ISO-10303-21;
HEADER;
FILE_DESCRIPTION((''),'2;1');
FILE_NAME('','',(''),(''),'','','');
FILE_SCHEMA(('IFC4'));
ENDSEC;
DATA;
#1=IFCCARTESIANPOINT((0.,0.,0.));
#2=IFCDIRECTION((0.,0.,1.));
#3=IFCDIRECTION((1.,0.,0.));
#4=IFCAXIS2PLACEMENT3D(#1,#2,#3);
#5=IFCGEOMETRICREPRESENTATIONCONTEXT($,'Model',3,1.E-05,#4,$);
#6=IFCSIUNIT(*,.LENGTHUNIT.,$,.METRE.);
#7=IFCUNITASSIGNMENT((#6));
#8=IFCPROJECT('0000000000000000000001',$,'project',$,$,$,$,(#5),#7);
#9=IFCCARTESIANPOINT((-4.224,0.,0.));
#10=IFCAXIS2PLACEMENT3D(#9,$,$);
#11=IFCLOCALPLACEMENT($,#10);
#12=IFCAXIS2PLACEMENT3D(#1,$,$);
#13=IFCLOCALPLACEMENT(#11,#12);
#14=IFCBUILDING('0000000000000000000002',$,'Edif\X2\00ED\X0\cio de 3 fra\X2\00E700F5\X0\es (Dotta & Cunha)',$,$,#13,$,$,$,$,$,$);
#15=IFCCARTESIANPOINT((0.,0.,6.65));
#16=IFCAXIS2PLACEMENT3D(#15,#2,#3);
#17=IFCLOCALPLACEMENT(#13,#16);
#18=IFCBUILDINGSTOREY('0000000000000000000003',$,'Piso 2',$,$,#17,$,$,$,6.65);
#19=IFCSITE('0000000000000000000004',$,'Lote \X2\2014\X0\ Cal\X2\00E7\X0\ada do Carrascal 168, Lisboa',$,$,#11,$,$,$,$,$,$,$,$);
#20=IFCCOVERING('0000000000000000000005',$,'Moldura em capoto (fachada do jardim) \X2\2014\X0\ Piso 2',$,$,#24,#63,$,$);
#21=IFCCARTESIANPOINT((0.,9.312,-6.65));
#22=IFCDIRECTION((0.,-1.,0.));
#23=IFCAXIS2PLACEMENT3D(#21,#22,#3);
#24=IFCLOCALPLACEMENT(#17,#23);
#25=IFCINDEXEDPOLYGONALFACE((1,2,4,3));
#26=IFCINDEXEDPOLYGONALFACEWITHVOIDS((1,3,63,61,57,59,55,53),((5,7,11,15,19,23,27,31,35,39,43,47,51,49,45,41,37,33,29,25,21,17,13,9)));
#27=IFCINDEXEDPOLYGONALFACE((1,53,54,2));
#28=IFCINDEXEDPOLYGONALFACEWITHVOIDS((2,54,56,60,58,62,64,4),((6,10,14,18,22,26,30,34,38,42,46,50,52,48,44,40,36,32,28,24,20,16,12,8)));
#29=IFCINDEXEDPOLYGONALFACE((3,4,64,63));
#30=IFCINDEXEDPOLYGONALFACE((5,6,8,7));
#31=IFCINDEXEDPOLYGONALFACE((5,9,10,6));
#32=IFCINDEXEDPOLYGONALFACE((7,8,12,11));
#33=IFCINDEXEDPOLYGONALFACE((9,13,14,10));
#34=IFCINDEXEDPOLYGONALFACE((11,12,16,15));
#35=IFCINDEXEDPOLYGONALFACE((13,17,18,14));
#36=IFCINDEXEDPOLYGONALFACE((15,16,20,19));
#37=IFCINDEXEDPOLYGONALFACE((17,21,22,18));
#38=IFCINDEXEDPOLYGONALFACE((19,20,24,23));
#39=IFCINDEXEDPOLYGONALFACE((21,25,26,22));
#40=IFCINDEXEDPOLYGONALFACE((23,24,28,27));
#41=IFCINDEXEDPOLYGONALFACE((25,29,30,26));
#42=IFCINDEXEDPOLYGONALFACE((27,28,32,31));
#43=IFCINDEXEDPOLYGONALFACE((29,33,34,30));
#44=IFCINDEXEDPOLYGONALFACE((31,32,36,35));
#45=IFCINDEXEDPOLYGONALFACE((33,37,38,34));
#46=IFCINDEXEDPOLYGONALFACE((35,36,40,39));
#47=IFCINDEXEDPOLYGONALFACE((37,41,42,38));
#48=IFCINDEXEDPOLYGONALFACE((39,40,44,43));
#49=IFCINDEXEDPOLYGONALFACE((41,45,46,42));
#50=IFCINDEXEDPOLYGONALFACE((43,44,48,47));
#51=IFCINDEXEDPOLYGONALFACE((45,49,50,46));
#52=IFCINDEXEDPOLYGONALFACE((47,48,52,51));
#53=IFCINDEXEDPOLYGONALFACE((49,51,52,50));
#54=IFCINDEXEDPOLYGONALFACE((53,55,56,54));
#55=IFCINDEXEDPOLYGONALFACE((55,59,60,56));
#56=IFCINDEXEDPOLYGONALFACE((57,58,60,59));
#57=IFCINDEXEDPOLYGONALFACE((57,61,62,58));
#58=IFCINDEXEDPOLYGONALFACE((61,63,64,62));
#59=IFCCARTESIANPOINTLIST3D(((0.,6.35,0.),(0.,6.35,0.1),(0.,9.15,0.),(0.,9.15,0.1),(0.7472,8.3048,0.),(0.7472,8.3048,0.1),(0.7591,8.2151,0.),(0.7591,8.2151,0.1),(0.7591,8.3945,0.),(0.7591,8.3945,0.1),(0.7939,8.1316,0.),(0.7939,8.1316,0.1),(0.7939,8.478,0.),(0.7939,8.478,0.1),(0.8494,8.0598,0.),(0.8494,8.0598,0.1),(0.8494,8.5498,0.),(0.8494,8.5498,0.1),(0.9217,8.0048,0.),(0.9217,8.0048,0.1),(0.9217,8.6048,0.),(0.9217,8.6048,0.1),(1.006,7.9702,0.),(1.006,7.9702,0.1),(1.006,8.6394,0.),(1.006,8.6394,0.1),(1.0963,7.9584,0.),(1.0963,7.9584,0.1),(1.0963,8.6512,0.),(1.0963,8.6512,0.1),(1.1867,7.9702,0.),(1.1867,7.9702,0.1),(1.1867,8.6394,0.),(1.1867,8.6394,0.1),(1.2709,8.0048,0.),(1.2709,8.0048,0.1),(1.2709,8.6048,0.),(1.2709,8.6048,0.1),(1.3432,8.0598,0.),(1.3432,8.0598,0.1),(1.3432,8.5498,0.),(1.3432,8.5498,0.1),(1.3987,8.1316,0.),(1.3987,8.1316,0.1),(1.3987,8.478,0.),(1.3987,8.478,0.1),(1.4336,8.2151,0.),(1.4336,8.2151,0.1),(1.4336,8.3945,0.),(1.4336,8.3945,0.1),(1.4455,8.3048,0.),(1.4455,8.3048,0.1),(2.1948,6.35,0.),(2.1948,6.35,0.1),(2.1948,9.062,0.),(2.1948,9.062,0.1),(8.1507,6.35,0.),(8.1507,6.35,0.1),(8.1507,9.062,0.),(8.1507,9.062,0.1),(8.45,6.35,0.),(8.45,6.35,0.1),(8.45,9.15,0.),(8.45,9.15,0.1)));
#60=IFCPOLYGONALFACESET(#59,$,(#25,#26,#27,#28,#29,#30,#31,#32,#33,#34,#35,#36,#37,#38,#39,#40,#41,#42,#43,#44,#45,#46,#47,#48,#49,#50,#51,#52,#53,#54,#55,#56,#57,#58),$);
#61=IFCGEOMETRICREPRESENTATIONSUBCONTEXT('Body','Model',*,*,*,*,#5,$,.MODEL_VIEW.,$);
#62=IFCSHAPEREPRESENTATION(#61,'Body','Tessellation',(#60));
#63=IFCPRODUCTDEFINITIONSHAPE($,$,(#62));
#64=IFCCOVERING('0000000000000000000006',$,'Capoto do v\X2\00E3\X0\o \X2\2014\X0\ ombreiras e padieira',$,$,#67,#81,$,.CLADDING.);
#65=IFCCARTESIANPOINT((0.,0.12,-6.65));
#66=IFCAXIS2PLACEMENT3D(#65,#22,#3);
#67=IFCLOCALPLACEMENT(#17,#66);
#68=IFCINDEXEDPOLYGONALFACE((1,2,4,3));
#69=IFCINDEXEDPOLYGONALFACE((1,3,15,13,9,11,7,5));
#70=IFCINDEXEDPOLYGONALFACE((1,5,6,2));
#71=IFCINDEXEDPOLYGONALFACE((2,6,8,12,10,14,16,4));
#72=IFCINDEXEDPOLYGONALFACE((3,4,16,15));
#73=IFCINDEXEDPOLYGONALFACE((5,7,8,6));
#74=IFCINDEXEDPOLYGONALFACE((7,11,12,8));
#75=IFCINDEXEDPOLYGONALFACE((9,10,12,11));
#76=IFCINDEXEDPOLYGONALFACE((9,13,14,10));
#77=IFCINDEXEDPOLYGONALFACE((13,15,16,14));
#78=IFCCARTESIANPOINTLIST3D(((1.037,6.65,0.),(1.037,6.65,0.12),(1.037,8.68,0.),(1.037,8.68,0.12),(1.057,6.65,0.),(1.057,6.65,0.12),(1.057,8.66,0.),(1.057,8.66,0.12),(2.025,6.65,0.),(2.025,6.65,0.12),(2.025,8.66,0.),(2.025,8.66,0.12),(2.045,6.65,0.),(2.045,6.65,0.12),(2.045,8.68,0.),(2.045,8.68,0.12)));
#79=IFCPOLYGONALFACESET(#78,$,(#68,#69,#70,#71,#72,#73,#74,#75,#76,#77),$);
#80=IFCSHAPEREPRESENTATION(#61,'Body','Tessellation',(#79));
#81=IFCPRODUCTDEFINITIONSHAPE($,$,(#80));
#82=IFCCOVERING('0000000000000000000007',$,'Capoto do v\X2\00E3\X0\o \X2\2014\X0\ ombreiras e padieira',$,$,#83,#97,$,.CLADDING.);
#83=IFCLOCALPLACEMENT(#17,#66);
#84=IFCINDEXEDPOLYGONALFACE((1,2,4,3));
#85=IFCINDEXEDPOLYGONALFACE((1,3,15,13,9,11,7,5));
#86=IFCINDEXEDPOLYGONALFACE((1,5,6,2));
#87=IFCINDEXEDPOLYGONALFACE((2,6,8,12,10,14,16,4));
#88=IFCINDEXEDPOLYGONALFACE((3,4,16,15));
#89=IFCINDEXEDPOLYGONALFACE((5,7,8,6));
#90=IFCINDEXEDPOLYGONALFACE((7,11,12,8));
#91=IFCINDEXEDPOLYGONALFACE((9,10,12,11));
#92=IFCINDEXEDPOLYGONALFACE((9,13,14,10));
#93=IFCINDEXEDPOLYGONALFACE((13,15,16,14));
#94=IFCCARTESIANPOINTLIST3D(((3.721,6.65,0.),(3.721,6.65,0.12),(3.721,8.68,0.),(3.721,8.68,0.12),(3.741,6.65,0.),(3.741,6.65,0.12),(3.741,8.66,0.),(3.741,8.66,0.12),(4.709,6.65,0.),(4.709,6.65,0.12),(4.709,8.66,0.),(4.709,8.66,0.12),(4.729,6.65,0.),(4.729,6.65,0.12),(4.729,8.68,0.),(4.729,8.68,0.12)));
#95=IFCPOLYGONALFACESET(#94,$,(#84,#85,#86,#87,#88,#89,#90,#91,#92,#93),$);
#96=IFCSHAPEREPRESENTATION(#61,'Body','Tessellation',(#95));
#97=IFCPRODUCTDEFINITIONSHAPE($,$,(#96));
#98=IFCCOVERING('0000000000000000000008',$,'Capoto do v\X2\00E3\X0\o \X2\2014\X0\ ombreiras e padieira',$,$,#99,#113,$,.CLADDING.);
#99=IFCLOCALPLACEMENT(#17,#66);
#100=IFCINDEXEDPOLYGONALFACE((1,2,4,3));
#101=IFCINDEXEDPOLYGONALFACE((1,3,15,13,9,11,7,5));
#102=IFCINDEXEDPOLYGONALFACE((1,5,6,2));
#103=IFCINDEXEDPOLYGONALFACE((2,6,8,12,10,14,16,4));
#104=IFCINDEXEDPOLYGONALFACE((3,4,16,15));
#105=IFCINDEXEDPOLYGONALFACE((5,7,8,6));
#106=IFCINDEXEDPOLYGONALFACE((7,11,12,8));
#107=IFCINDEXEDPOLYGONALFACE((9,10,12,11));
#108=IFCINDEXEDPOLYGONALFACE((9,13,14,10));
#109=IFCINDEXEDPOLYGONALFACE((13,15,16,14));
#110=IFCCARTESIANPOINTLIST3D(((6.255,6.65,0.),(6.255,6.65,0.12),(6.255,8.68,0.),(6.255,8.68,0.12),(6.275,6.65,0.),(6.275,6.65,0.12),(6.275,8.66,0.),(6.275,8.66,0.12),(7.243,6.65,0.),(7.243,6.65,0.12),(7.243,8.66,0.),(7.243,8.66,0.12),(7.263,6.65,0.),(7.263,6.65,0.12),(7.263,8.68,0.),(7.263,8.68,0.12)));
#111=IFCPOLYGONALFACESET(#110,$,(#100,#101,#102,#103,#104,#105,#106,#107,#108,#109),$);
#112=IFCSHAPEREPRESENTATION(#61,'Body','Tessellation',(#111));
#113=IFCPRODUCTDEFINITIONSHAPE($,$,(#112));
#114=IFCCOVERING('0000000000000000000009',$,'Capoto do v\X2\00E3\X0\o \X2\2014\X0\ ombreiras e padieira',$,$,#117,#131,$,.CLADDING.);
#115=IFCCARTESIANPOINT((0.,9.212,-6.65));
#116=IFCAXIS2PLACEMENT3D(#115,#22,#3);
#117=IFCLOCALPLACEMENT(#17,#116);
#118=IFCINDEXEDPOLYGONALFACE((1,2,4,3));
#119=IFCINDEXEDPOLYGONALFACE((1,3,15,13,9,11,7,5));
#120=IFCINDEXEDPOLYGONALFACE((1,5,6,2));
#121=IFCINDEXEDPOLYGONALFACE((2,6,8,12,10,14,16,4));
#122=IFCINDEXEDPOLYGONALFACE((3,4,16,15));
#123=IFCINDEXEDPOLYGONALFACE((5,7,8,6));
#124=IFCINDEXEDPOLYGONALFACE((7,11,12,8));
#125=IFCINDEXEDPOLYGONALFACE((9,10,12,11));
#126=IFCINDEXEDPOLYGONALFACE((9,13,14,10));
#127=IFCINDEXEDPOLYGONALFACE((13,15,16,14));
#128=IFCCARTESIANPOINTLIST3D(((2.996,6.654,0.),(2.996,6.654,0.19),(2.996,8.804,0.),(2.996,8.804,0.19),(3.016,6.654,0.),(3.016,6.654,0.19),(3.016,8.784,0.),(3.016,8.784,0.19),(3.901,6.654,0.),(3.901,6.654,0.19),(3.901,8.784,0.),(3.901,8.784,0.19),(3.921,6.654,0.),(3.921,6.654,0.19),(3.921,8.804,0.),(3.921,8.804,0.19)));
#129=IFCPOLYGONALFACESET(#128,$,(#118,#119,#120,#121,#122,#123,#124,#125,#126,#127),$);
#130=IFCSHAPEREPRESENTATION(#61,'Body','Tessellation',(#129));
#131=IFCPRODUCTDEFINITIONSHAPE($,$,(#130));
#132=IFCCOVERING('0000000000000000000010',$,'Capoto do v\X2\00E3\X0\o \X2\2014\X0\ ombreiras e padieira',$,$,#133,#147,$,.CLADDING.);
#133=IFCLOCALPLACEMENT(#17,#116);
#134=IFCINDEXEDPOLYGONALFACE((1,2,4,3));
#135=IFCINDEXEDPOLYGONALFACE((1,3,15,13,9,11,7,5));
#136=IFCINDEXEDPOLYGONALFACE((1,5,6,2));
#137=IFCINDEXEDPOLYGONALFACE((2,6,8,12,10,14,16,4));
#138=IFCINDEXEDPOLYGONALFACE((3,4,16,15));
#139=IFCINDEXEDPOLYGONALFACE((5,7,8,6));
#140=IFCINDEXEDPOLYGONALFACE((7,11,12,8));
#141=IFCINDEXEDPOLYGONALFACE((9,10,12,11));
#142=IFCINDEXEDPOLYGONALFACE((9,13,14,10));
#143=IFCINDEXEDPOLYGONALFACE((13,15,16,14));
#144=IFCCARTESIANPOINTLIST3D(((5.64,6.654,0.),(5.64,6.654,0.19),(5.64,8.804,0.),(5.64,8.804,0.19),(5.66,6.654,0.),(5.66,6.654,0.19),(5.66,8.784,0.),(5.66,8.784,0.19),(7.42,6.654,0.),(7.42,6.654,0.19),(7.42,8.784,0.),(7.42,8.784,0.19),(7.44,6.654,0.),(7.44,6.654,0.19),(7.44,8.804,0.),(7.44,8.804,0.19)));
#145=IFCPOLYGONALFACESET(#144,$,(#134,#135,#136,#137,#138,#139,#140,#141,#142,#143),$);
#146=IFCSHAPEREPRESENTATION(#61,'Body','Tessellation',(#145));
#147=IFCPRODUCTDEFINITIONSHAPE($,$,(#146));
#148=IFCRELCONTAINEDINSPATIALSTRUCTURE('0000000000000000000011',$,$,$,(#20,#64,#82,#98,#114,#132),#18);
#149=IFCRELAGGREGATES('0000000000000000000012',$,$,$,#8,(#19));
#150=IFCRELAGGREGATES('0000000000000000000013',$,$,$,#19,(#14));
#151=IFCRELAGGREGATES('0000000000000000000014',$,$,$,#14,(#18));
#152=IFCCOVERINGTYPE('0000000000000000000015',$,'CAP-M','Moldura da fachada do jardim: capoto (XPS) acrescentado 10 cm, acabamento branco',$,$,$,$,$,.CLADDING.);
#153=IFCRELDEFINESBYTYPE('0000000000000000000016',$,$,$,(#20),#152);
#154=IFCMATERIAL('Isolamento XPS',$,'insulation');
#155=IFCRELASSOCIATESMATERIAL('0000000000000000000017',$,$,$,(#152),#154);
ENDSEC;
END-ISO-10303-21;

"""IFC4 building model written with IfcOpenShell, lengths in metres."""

from ifc_helpers import new_model, si_unit, frame, origin, origin_with_axes, place, context, subcontext, project, spatial, line, indexed_curve, outline, extrude, material, type_object, element, save


model = new_model("IFC4")

# Units and contexts
model_context = context("Model", 3, precision=1e-05, world=origin_with_axes())
body_context = subcontext(model_context, "Body", "Model", "MODEL_VIEW")
ifc_project = project(units=[si_unit("LENGTHUNIT", "METRE")], contexts=[model_context])

# Site, building, storey
site_placement = place(None, frame((-4.224, 0.0, 0.0)))
site = spatial("IfcSite", under=ifc_project, at=site_placement, Name="Lote — Calçada do Carrascal 168, Lisboa")
building_placement = place(site_placement, origin())
building = spatial("IfcBuilding", under=site, at=building_placement, Name="Edifício de 3 frações (Dotta & Cunha)")
storey_placement = place(building_placement, frame((0.0, 0.0, 6.65), z_axis=(0.0, 0.0, 1.0), x_axis=(1.0, 0.0, 0.0)))
storey = spatial("IfcBuildingStorey", under=building, at=storey_placement, Name="Piso 2", Elevation=6.65)

# Covering
ifc_material_1 = material(Name="Isolamento XPS", Category="insulation")
covering_type_1 = type_object("IfcCoveringType", Name="CAP-M", Description="Moldura da fachada do jardim: capoto (XPS) acrescentado 10 cm, acabamento branco", PredefinedType="CLADDING", material=ifc_material_1)
covering_1_placement = place(storey_placement, frame((0.0, 9.312, -6.65), z_axis=(0.0, -1.0, 0.0), x_axis=(1.0, 0.0, 0.0)))
element("IfcCovering", 1, at=covering_1_placement, inside=storey, type_object=covering_type_1, Name="Moldura em capoto (fachada do jardim) — Piso 2", context=body_context, shape_type="SweptSolid", body=[
    extrude(outline(indexed_curve([(8.45, 6.35), (8.1507, 6.35), (8.1507, 9.062), (2.1948, 9.062), (2.1948, 6.35), (0.0, 6.35), (0.0, 9.15), (8.45, 9.15)], segments=[line(1, 2, 3, 4, 5, 6, 7, 8, 1)]), holes=[indexed_curve([(0.9217, 8.6048), (0.8494, 8.5498), (0.7939, 8.478), (0.7591, 8.3945), (0.7472, 8.3048), (0.7591, 8.2151), (0.7939, 8.1316), (0.8494, 8.0598), (0.9217, 8.0048), (1.006, 7.9702), (1.0963, 7.9584), (1.1867, 7.9702), (1.2709, 8.0048), (1.3432, 8.0598), (1.3987, 8.1316), (1.4336, 8.2151), (1.4455, 8.3048), (1.4336, 8.3945), (1.3987, 8.478), (1.3432, 8.5498), (1.2709, 8.6048), (1.1867, 8.6394), (1.0963, 8.6512), (1.006, 8.6394)], segments=[line(1, 2, 3, 4, 5, 6, 7, 8, 9, 10, 11, 12, 13, 14, 15, 16, 17, 18, 19, 20, 21, 22, 23, 24, 1)])]), origin_with_axes(), (0.0, 0.0, 1.0), 0.1),
])

# Coverings
covering_2_placement = place(storey_placement, frame((0.0, 0.12, -6.65), z_axis=(0.0, -1.0, 0.0), x_axis=(1.0, 0.0, 0.0)))
element("IfcCovering", 2, at=covering_2_placement, inside=storey, Name="Capoto do vão — ombreiras e padieira", PredefinedType="CLADDING", context=body_context, shape_type="SweptSolid", body=[
    extrude(outline(indexed_curve([(1.037, 6.65), (1.037, 8.68), (2.045, 8.68), (2.045, 6.65), (2.025, 6.65), (2.025, 8.66), (1.057, 8.66), (1.057, 6.65)], segments=[line(1, 2, 3, 4, 5, 6, 7, 8, 1)])), origin_with_axes(), (0.0, 0.0, 1.0), 0.12),
])
covering_3_placement = place(storey_placement, frame((0.0, 0.12, -6.65), z_axis=(0.0, -1.0, 0.0), x_axis=(1.0, 0.0, 0.0)))
element("IfcCovering", 3, at=covering_3_placement, inside=storey, Name="Capoto do vão — ombreiras e padieira", PredefinedType="CLADDING", context=body_context, shape_type="SweptSolid", body=[
    extrude(outline(indexed_curve([(3.721, 6.65), (3.721, 8.68), (4.729, 8.68), (4.729, 6.65), (4.709, 6.65), (4.709, 8.66), (3.741, 8.66), (3.741, 6.65)], segments=[line(1, 2, 3, 4, 5, 6, 7, 8, 1)])), origin_with_axes(), (0.0, 0.0, 1.0), 0.12),
])
covering_4_placement = place(storey_placement, frame((0.0, 0.12, -6.65), z_axis=(0.0, -1.0, 0.0), x_axis=(1.0, 0.0, 0.0)))
element("IfcCovering", 4, at=covering_4_placement, inside=storey, Name="Capoto do vão — ombreiras e padieira", PredefinedType="CLADDING", context=body_context, shape_type="SweptSolid", body=[
    extrude(outline(indexed_curve([(6.255, 6.65), (6.255, 8.68), (7.263, 8.68), (7.263, 6.65), (7.243, 6.65), (7.243, 8.66), (6.275, 8.66), (6.275, 6.65)], segments=[line(1, 2, 3, 4, 5, 6, 7, 8, 1)])), origin_with_axes(), (0.0, 0.0, 1.0), 0.12),
])
covering_5_placement = place(storey_placement, frame((0.0, 9.212, -6.65), z_axis=(0.0, -1.0, 0.0), x_axis=(1.0, 0.0, 0.0)))
element("IfcCovering", 5, at=covering_5_placement, inside=storey, Name="Capoto do vão — ombreiras e padieira", PredefinedType="CLADDING", context=body_context, shape_type="SweptSolid", body=[
    extrude(outline(indexed_curve([(2.996, 6.654), (2.996, 8.804), (3.921, 8.804), (3.921, 6.654), (3.901, 6.654), (3.901, 8.784), (3.016, 8.784), (3.016, 6.654)], segments=[line(1, 2, 3, 4, 5, 6, 7, 8, 1)])), origin_with_axes(), (0.0, 0.0, 1.0), 0.19),
])
covering_6_placement = place(storey_placement, frame((0.0, 9.212, -6.65), z_axis=(0.0, -1.0, 0.0), x_axis=(1.0, 0.0, 0.0)))
element("IfcCovering", 6, at=covering_6_placement, inside=storey, Name="Capoto do vão — ombreiras e padieira", PredefinedType="CLADDING", context=body_context, shape_type="SweptSolid", body=[
    extrude(outline(indexed_curve([(5.64, 6.654), (5.64, 8.804), (7.44, 8.804), (7.44, 6.654), (7.42, 6.654), (7.42, 8.784), (5.66, 8.784), (5.66, 6.654)], segments=[line(1, 2, 3, 4, 5, 6, 7, 8, 1)])), origin_with_axes(), (0.0, 0.0, 1.0), 0.19),
])

save(model, "model.ifc")
